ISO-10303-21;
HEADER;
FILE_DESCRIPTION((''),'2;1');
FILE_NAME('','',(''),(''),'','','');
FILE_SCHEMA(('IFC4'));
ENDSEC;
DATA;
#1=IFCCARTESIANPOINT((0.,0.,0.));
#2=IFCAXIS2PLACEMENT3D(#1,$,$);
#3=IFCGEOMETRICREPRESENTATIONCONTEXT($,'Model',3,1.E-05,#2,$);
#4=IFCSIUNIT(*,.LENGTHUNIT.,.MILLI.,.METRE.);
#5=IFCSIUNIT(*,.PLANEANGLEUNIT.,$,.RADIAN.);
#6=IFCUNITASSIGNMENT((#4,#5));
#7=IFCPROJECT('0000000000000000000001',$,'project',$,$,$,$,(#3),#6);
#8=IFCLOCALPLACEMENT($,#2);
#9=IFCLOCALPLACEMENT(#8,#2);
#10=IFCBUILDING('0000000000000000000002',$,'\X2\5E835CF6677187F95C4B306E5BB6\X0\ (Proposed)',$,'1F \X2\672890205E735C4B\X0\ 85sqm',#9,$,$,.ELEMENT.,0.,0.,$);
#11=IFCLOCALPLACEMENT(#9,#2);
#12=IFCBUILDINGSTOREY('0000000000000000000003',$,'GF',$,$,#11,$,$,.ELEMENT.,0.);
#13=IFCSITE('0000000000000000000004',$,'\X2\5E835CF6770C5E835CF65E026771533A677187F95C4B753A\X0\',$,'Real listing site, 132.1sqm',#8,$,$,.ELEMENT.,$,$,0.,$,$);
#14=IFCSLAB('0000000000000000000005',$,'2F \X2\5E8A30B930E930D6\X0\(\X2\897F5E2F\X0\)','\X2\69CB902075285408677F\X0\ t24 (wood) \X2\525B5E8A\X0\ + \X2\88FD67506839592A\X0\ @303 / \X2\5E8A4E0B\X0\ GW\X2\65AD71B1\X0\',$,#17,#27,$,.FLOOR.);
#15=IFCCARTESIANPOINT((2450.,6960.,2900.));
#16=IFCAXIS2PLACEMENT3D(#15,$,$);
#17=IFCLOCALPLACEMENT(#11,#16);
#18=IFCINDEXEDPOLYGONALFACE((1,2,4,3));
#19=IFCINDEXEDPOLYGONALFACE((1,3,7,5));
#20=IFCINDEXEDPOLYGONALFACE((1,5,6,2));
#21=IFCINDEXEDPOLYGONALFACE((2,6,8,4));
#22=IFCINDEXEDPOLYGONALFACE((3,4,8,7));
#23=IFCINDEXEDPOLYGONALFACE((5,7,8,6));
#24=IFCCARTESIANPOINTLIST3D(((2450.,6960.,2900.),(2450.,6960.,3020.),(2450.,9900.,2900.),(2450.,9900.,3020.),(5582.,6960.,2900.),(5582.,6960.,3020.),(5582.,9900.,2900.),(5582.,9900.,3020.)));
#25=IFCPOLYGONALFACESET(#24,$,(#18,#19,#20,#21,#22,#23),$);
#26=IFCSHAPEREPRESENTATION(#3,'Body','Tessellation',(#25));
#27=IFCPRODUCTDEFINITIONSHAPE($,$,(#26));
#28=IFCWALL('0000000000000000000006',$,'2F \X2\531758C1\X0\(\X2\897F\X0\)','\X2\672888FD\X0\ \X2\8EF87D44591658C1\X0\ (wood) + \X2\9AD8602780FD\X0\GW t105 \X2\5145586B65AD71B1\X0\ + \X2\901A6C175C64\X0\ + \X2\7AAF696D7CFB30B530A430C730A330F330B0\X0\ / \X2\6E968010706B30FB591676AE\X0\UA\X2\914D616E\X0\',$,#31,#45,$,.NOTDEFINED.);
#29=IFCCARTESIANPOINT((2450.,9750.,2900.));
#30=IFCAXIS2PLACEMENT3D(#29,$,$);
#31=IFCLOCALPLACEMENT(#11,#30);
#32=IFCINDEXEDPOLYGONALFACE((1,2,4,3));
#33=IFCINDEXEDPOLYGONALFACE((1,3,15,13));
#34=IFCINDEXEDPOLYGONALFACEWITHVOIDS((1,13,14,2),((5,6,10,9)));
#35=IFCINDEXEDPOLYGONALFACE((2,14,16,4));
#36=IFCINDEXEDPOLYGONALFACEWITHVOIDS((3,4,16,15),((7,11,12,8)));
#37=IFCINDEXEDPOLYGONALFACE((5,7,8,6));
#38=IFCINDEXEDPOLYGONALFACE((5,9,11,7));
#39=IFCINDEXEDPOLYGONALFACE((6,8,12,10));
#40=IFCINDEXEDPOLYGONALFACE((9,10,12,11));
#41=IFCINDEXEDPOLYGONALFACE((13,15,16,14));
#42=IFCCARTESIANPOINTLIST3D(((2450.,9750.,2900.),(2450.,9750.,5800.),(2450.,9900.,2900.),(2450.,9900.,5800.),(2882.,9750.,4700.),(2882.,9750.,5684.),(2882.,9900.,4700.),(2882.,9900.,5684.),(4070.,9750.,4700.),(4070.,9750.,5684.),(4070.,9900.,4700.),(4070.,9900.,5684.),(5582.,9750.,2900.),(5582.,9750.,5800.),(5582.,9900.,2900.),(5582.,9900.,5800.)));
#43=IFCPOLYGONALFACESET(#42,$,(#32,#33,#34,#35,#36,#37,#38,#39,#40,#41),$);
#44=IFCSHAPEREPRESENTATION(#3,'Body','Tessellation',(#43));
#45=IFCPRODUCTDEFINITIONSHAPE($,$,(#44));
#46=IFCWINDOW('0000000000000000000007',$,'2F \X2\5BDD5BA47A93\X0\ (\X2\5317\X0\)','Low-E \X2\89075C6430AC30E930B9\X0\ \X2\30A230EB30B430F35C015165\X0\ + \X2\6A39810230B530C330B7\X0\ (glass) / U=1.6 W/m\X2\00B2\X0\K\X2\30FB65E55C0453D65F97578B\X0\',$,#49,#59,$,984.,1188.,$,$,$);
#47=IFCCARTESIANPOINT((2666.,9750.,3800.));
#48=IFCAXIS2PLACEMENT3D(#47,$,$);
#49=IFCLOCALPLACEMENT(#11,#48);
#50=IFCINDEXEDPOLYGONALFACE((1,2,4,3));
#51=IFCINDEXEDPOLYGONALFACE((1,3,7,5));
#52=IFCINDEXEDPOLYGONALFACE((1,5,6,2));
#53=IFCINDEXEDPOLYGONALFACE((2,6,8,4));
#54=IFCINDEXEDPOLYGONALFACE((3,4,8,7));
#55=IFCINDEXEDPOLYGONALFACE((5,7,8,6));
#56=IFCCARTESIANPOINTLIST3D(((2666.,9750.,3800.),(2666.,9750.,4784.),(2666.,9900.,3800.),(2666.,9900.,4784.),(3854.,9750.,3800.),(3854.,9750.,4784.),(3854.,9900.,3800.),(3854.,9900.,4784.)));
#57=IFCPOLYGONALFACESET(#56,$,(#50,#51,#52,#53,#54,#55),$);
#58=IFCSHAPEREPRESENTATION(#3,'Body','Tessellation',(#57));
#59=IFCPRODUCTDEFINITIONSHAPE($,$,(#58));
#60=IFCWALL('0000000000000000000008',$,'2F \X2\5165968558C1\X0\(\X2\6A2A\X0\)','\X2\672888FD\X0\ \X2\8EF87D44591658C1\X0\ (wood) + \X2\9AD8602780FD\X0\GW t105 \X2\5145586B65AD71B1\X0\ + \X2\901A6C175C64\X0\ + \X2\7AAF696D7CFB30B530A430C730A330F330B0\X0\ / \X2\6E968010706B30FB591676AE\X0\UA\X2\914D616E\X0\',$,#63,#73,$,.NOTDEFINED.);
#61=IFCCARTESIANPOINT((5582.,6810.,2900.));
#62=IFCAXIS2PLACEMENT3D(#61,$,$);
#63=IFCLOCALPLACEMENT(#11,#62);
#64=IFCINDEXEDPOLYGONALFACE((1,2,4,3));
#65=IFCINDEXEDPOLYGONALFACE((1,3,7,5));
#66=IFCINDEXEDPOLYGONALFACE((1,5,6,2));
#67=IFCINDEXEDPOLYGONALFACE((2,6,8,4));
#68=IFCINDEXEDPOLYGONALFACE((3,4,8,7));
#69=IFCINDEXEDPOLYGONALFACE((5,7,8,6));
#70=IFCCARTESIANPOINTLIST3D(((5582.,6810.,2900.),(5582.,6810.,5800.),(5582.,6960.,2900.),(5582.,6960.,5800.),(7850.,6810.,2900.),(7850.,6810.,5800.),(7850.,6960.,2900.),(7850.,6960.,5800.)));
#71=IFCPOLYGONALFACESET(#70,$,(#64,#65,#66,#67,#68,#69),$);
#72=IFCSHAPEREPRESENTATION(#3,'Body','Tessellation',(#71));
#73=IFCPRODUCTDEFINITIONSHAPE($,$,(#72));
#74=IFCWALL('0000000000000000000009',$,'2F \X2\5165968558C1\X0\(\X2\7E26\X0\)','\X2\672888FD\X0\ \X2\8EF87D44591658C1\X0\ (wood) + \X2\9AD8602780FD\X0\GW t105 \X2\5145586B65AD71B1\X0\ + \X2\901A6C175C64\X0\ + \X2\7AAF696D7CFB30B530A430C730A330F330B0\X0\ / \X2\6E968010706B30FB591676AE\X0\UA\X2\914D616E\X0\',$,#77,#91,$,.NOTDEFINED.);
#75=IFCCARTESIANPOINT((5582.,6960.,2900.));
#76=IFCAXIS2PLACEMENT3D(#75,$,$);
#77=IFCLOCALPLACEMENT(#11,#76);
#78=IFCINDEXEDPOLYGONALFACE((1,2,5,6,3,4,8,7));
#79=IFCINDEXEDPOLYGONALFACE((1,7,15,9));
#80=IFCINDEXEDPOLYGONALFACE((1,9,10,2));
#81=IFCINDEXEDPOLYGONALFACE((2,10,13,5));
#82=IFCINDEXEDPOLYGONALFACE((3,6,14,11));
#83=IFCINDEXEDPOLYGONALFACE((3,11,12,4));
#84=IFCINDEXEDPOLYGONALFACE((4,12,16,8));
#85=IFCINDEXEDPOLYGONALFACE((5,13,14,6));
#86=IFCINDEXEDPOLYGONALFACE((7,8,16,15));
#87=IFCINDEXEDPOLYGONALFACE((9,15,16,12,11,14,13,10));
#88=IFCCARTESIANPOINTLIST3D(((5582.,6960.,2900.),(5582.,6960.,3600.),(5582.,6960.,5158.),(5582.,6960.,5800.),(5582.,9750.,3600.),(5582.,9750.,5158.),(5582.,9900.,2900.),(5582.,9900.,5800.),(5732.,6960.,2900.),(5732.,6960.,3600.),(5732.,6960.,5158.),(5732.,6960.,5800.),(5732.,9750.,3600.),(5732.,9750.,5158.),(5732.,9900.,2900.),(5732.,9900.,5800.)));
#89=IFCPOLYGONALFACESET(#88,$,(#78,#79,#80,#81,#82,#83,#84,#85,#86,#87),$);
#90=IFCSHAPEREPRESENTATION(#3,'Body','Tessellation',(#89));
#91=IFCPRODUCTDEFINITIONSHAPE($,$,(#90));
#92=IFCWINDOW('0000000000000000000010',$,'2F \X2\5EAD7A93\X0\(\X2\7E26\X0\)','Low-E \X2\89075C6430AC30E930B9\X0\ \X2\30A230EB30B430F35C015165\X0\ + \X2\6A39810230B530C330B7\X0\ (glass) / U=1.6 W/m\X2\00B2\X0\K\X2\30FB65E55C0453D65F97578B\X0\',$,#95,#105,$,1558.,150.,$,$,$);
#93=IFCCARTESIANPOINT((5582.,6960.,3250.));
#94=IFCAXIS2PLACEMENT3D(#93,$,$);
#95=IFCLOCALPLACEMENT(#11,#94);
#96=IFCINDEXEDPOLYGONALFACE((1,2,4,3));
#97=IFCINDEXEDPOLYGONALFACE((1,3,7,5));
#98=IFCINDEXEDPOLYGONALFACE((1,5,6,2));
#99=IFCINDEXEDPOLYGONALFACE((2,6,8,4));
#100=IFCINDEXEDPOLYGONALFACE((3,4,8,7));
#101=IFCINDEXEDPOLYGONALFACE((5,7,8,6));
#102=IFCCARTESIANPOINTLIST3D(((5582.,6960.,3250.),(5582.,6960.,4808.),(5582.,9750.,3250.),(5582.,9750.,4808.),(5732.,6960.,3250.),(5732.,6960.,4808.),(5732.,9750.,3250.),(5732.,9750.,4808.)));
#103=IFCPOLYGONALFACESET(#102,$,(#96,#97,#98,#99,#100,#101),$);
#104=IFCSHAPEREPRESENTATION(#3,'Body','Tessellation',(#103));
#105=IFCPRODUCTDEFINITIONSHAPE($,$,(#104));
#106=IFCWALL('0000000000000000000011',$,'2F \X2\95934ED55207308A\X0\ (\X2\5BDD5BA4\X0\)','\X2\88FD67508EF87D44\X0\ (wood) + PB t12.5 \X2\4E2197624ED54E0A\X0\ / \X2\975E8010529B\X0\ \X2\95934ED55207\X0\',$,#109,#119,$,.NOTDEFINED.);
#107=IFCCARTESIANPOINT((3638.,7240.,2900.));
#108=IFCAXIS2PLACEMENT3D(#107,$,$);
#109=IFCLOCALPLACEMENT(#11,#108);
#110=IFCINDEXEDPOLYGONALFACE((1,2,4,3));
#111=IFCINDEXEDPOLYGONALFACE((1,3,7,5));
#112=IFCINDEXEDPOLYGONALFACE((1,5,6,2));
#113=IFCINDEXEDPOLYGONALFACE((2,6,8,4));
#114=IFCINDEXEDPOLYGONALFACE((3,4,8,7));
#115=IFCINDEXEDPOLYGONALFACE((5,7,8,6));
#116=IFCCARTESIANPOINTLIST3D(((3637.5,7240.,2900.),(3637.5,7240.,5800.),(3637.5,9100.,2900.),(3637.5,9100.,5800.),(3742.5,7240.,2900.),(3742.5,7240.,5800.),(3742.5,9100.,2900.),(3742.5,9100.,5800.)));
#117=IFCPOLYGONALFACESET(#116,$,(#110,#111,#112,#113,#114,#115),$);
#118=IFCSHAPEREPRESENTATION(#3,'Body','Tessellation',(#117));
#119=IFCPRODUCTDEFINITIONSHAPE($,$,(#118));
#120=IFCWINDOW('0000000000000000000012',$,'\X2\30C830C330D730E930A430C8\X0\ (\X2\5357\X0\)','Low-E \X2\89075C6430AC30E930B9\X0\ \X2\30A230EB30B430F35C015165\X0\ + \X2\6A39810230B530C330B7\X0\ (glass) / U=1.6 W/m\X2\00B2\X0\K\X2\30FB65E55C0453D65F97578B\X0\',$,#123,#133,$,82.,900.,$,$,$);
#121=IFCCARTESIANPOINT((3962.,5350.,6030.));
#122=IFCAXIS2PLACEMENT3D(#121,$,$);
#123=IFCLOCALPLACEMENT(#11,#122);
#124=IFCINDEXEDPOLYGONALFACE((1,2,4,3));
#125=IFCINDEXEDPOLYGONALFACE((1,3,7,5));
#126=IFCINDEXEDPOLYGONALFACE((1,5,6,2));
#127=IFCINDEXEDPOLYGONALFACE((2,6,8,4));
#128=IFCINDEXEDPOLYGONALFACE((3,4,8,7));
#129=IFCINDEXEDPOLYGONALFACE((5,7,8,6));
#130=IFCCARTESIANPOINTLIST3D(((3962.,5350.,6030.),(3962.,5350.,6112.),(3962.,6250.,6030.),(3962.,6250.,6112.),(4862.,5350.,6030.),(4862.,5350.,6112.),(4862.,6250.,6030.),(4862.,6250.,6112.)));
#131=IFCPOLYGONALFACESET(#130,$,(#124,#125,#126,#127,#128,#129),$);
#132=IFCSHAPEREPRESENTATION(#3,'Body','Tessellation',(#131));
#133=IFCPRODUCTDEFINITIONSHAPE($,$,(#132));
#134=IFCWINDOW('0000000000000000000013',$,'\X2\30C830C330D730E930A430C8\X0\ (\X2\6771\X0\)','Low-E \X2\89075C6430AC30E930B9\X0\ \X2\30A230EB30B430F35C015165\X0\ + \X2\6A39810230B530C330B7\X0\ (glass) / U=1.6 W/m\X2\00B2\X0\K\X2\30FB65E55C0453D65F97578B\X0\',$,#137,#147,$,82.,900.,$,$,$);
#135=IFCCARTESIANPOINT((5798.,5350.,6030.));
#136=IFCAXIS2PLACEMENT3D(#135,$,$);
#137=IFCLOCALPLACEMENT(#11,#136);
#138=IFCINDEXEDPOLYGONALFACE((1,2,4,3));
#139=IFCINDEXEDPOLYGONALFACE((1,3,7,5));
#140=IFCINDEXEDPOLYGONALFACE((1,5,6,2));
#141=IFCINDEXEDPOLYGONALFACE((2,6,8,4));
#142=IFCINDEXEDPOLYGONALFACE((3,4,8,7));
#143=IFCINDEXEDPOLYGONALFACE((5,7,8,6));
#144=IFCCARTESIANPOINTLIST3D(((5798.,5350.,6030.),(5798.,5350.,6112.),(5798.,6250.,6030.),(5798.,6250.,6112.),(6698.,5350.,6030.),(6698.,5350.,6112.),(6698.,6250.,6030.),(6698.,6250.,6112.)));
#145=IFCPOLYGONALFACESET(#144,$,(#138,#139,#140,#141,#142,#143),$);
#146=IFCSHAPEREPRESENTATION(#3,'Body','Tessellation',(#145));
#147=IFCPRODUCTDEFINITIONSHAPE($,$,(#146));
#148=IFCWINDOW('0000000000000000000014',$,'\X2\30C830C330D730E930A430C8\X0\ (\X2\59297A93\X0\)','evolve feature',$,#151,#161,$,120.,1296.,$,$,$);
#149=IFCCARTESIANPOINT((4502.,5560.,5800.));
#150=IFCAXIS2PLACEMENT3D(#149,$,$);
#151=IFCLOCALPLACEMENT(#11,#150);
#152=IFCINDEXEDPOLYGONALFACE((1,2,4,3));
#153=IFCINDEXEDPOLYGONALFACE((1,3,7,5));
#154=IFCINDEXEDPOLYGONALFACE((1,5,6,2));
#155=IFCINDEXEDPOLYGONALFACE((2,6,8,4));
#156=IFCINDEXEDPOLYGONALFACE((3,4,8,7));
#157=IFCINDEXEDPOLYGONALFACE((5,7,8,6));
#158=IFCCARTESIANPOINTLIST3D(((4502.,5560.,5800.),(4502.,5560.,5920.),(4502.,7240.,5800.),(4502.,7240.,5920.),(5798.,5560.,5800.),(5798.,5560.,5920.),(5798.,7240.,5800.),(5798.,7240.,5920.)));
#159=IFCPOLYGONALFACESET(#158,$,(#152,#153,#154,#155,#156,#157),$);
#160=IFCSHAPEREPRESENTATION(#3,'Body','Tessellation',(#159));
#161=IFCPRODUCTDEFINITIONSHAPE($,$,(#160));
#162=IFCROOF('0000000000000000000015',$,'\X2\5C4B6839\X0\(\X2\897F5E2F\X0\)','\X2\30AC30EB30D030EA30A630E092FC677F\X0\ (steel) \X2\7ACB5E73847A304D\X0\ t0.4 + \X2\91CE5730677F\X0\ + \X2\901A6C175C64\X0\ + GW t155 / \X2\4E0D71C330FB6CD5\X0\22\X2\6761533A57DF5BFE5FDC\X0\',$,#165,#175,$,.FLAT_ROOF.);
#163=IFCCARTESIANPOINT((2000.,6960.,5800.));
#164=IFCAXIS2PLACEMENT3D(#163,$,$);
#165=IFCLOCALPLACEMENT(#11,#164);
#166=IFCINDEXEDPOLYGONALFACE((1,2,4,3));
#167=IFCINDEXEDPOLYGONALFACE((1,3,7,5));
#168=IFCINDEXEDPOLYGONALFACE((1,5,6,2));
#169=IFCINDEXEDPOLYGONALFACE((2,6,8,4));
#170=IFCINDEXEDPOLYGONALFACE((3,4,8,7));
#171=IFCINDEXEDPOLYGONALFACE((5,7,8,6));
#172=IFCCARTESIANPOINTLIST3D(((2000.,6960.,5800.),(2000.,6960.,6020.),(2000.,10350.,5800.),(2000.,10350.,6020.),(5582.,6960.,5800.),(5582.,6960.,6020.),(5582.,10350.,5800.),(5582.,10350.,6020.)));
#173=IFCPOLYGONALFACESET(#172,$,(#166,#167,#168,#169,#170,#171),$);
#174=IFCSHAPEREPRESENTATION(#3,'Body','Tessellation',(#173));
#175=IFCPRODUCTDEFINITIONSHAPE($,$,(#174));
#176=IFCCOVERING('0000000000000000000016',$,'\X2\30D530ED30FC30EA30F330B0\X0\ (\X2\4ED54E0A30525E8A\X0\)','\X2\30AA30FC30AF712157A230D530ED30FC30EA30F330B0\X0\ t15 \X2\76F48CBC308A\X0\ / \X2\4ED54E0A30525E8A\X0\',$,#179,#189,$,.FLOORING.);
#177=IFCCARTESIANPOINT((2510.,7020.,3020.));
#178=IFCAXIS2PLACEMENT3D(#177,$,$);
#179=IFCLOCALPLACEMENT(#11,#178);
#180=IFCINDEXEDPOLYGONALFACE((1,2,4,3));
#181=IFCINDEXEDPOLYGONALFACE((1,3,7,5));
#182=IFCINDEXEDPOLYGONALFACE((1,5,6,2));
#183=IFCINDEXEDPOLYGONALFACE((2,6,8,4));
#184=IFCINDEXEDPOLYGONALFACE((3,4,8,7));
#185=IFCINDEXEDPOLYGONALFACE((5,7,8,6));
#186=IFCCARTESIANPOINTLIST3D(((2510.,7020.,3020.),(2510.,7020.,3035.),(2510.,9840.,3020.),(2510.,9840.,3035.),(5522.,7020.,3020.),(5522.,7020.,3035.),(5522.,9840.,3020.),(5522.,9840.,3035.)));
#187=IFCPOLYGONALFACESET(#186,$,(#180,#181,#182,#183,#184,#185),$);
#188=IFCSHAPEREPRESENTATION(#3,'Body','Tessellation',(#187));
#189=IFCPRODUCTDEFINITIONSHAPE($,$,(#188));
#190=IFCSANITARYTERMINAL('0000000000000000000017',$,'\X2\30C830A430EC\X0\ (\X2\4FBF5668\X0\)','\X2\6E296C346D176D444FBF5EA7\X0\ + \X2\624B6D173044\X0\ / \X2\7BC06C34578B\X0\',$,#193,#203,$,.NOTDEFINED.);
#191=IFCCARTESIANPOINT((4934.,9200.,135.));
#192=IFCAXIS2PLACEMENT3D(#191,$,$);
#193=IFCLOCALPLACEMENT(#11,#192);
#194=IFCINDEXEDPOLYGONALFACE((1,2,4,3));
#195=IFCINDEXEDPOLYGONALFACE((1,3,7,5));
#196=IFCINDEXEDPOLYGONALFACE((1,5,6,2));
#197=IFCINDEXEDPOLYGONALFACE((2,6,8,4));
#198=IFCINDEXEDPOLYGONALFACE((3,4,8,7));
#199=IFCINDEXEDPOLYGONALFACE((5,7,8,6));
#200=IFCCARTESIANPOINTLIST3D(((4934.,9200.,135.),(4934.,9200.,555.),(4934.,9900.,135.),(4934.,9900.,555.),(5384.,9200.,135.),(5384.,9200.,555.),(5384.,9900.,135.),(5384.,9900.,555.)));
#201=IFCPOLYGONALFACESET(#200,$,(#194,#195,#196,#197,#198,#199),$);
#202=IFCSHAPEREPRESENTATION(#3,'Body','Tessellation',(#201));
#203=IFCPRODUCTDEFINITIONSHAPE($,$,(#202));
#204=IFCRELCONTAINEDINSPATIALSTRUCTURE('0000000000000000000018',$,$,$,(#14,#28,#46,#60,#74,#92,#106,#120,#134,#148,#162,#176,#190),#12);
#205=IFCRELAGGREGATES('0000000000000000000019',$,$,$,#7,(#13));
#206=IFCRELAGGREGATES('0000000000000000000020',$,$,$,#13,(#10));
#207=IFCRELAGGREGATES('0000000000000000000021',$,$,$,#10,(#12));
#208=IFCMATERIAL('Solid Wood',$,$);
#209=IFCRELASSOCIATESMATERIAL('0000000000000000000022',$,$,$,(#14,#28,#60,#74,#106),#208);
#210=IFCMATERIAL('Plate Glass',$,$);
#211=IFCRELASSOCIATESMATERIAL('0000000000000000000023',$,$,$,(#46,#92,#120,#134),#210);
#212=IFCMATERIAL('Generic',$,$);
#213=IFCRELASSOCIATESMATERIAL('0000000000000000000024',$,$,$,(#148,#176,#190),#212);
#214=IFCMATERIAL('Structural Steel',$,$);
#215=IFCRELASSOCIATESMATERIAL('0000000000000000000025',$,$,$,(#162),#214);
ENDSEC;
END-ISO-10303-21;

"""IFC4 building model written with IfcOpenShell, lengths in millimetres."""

from ifc_helpers import new_model, si_unit, frame, frame_2d, origin, place, context, project, spatial, rectangle, extrude, material, element, fill, save


model = new_model("IFC4")

# Units and contexts
model_context = context("Model", 3, precision=1e-05, world=origin())
ifc_project = project(units=[si_unit("LENGTHUNIT", "METRE", prefix="MILLI"), si_unit("PLANEANGLEUNIT", "RADIAN")], contexts=[model_context])

# Site, building, storey
site_placement = place(None, origin())
site = spatial("IfcSite", under=ifc_project, at=site_placement, Name="広島県広島市東区東蟹屋町", ObjectType="Real listing site, 132.1sqm", CompositionType="ELEMENT", RefElevation=0.0)
building_placement = place(site_placement, origin())
building = spatial("IfcBuilding", under=site, at=building_placement, Name="広島東蟹屋の家 (Proposed)", ObjectType="1F 木造平屋 85sqm", CompositionType="ELEMENT", ElevationOfRefHeight=0.0, ElevationOfTerrain=0.0)
storey_placement = place(building_placement, origin())
storey = spatial("IfcBuildingStorey", under=building, at=storey_placement, Name="GF", CompositionType="ELEMENT", Elevation=0.0)

# Slab
ifc_material_1 = material(Name="Solid Wood")
slab_placement = place(storey_placement, frame((2450.0, 6960.0, 2900.0)))
element("IfcSlab", 1, at=slab_placement, inside=storey, material=ifc_material_1, Name="2F 床スラブ(西帯)", Description="構造用合板 t24 (wood) 剛床 + 製材根太 @303 / 床下 GW断熱", PredefinedType="FLOOR", context=model_context, shape_type="SweptSolid", body=[
    extrude(rectangle(XDim=3132.0, YDim=2940.0, at=frame_2d((1566.0, 1470.0))), frame((2450.0, 6960.0, 2900.0)), (0.0, 0.0, 1.0), 120.0),
])

# Wall, opening, window
wall_1_placement = place(storey_placement, frame((2450.0, 9750.0, 2900.0)))
wall_1 = element("IfcWall", 2, at=wall_1_placement, inside=storey, material=ifc_material_1, Name="2F 北壁(西)", Description="木製 軸組外壁 (wood) + 高性能GW t105 充填断熱 + 通気層 + 窯業系サイディング / 準耐火・外皮UA配慮", PredefinedType="NOTDEFINED", context=model_context, shape_type="SweptSolid", body=[
    extrude(rectangle(XDim=3132.0, YDim=150.0, at=frame_2d((1566.0, 75.0))), frame((2450.0, 9750.0, 2900.0)), (0.0, 0.0, 1.0), 2900.0),
])
opening_1_placement = place(storey_placement, frame((2666.0, 9750.0, 3800.0)))
opening_1 = element("IfcOpeningElement", 3, at=opening_1_placement, cuts=wall_1, PredefinedType="NOTDEFINED", context=model_context, shape_type="SweptSolid", body=[
    extrude(rectangle(XDim=1188.0, YDim=150.0, at=frame_2d((594.0, 75.0))), frame((2666.0, 9750.0, 3800.0)), (0.0, 0.0, 1.0), 984.0),
])
ifc_material_2 = material(Name="Plate Glass")
window_1_placement = place(storey_placement, frame((2666.0, 9750.0, 3800.0)))
window_1 = element("IfcWindow", 4, at=window_1_placement, inside=storey, material=ifc_material_2, Name="2F 寝室窓 (北)", Description="Low-E 複層ガラス アルゴン封入 + 樹脂サッシ (glass) / U=1.6 W/m²K・日射取得型", OverallHeight=984.0, OverallWidth=1188.0, context=model_context, shape_type="SweptSolid", body=[
    extrude(rectangle(XDim=1188.0, YDim=150.0, at=frame_2d((594.0, 75.0))), frame((2666.0, 9750.0, 3800.0)), (0.0, 0.0, 1.0), 984.0),
])
fill(opening_1, window_1)

# Wall
wall_2_placement = place(storey_placement, frame((5582.0, 6810.0, 2900.0)))
element("IfcWall", 5, at=wall_2_placement, inside=storey, material=ifc_material_1, Name="2F 入隅壁(横)", Description="木製 軸組外壁 (wood) + 高性能GW t105 充填断熱 + 通気層 + 窯業系サイディング / 準耐火・外皮UA配慮", PredefinedType="NOTDEFINED", context=model_context, shape_type="SweptSolid", body=[
    extrude(rectangle(XDim=2268.0, YDim=150.0, at=frame_2d((1134.0, 75.0))), frame((5582.0, 6810.0, 2900.0)), (0.0, 0.0, 1.0), 2900.0),
])

# Wall, opening, window
wall_3_placement = place(storey_placement, frame((5582.0, 6960.0, 2900.0)))
wall_3 = element("IfcWall", 6, at=wall_3_placement, inside=storey, material=ifc_material_1, Name="2F 入隅壁(縦)", Description="木製 軸組外壁 (wood) + 高性能GW t105 充填断熱 + 通気層 + 窯業系サイディング / 準耐火・外皮UA配慮", PredefinedType="NOTDEFINED", context=model_context, shape_type="SweptSolid", body=[
    extrude(rectangle(XDim=150.0, YDim=2940.0, at=frame_2d((75.0, 1470.0))), frame((5582.0, 6960.0, 2900.0)), (0.0, 0.0, 1.0), 2900.0),
])
opening_2_placement = place(storey_placement, frame((5582.0, 6960.0, 3250.0)))
opening_2 = element("IfcOpeningElement", 7, at=opening_2_placement, cuts=wall_3, PredefinedType="NOTDEFINED", context=model_context, shape_type="SweptSolid", body=[
    extrude(rectangle(XDim=150.0, YDim=2790.0, at=frame_2d((75.0, 1395.0))), frame((5582.0, 6960.0, 3250.0)), (0.0, 0.0, 1.0), 1558.0),
])
window_2_placement = place(storey_placement, frame((5582.0, 6960.0, 3250.0)))
window_2 = element("IfcWindow", 8, at=window_2_placement, inside=storey, material=ifc_material_2, Name="2F 庭窓(縦)", Description="Low-E 複層ガラス アルゴン封入 + 樹脂サッシ (glass) / U=1.6 W/m²K・日射取得型", OverallHeight=1558.0, OverallWidth=150.0, context=model_context, shape_type="SweptSolid", body=[
    extrude(rectangle(XDim=150.0, YDim=2790.0, at=frame_2d((75.0, 1395.0))), frame((5582.0, 6960.0, 3250.0)), (0.0, 0.0, 1.0), 1558.0),
])
fill(opening_2, window_2)

# Wall
wall_4_placement = place(storey_placement, frame((3638.0, 7240.0, 2900.0)))
element("IfcWall", 9, at=wall_4_placement, inside=storey, material=ifc_material_1, Name="2F 間仕切り (寝室)", Description="製材軸組 (wood) + PB t12.5 両面仕上 / 非耐力 間仕切", PredefinedType="NOTDEFINED", context=model_context, shape_type="SweptSolid", body=[
    extrude(rectangle(XDim=105.0, YDim=1860.0, at=frame_2d((52.0, 930.0))), frame((3638.0, 7240.0, 2900.0)), (0.0, 0.0, 1.0), 2900.0),
])

# Windows
window_3_placement = place(storey_placement, frame((3962.0, 5350.0, 6030.0)))
element("IfcWindow", 10, at=window_3_placement, inside=storey, material=ifc_material_2, Name="トップライト (南)", Description="Low-E 複層ガラス アルゴン封入 + 樹脂サッシ (glass) / U=1.6 W/m²K・日射取得型", OverallHeight=82.0, OverallWidth=900.0, context=model_context, shape_type="SweptSolid", body=[
    extrude(rectangle(XDim=900.0, YDim=900.0, at=frame_2d((450.0, 450.0))), frame((3962.0, 5350.0, 6030.0)), (0.0, 0.0, 1.0), 82.0),
])
window_4_placement = place(storey_placement, frame((5798.0, 5350.0, 6030.0)))
element("IfcWindow", 11, at=window_4_placement, inside=storey, material=ifc_material_2, Name="トップライト (東)", Description="Low-E 複層ガラス アルゴン封入 + 樹脂サッシ (glass) / U=1.6 W/m²K・日射取得型", OverallHeight=82.0, OverallWidth=900.0, context=model_context, shape_type="SweptSolid", body=[
    extrude(rectangle(XDim=900.0, YDim=900.0, at=frame_2d((450.0, 450.0))), frame((5798.0, 5350.0, 6030.0)), (0.0, 0.0, 1.0), 82.0),
])
ifc_material_3 = material(Name="Generic")
window_5_placement = place(storey_placement, frame((4502.0, 5560.0, 5800.0)))
element("IfcWindow", 12, at=window_5_placement, inside=storey, material=ifc_material_3, Name="トップライト (天窓)", Description="evolve feature", OverallHeight=120.0, OverallWidth=1296.0, context=model_context, shape_type="SweptSolid", body=[
    extrude(rectangle(XDim=1296.0, YDim=1680.0, at=frame_2d((648.0, 840.0))), frame((4502.0, 5560.0, 5800.0)), (0.0, 0.0, 1.0), 120.0),
])

# Roof
ifc_material_4 = material(Name="Structural Steel")
for number, where, name in (
    (13, (2000.0, 6960.0, 5800.0), "屋根(西帯)"),
):
    element("IfcRoof", number, at=place(storey_placement, frame(where)), inside=storey, material=ifc_material_4, Name=name, Description="ガルバリウム鋼板 (steel) 立平葺き t0.4 + 野地板 + 通気層 + GW t155 / 不燃・法22条区域対応", PredefinedType="FLAT_ROOF", context=model_context, shape_type="SweptSolid", body=[
        extrude(rectangle(XDim=3582.0, YDim=3390.0, at=frame_2d((1791.0, 1695.0))), frame((2000.0, 6960.0, 5800.0)), (0.0, 0.0, 1.0), 220.0),
    ])

# Covering
covering_placement = place(storey_placement, frame((2510.0, 7020.0, 3020.0)))
element("IfcCovering", 14, at=covering_placement, inside=storey, material=ifc_material_3, Name="フローリング (仕上げ床)", Description="オーク無垢フローリング t15 直貼り / 仕上げ床", PredefinedType="FLOORING", context=model_context, shape_type="SweptSolid", body=[
    extrude(rectangle(XDim=3012.0, YDim=2820.0, at=frame_2d((1506.0, 1410.0))), frame((2510.0, 7020.0, 3020.0)), (0.0, 0.0, 1.0), 15.0),
])

# Sanitary terminal
sanitary_terminal_placement = place(storey_placement, frame((4934.0, 9200.0, 135.0)))
element("IfcSanitaryTerminal", 15, at=sanitary_terminal_placement, inside=storey, material=ifc_material_3, Name="トイレ (便器)", Description="温水洗浄便座 + 手洗い / 節水型", PredefinedType="NOTDEFINED", context=model_context, shape_type="SweptSolid", body=[
    extrude(rectangle(XDim=450.0, YDim=700.0, at=frame_2d((225.0, 350.0))), frame((4934.0, 9200.0, 135.0)), (0.0, 0.0, 1.0), 420.0),
])

save(model, "model.ifc")
